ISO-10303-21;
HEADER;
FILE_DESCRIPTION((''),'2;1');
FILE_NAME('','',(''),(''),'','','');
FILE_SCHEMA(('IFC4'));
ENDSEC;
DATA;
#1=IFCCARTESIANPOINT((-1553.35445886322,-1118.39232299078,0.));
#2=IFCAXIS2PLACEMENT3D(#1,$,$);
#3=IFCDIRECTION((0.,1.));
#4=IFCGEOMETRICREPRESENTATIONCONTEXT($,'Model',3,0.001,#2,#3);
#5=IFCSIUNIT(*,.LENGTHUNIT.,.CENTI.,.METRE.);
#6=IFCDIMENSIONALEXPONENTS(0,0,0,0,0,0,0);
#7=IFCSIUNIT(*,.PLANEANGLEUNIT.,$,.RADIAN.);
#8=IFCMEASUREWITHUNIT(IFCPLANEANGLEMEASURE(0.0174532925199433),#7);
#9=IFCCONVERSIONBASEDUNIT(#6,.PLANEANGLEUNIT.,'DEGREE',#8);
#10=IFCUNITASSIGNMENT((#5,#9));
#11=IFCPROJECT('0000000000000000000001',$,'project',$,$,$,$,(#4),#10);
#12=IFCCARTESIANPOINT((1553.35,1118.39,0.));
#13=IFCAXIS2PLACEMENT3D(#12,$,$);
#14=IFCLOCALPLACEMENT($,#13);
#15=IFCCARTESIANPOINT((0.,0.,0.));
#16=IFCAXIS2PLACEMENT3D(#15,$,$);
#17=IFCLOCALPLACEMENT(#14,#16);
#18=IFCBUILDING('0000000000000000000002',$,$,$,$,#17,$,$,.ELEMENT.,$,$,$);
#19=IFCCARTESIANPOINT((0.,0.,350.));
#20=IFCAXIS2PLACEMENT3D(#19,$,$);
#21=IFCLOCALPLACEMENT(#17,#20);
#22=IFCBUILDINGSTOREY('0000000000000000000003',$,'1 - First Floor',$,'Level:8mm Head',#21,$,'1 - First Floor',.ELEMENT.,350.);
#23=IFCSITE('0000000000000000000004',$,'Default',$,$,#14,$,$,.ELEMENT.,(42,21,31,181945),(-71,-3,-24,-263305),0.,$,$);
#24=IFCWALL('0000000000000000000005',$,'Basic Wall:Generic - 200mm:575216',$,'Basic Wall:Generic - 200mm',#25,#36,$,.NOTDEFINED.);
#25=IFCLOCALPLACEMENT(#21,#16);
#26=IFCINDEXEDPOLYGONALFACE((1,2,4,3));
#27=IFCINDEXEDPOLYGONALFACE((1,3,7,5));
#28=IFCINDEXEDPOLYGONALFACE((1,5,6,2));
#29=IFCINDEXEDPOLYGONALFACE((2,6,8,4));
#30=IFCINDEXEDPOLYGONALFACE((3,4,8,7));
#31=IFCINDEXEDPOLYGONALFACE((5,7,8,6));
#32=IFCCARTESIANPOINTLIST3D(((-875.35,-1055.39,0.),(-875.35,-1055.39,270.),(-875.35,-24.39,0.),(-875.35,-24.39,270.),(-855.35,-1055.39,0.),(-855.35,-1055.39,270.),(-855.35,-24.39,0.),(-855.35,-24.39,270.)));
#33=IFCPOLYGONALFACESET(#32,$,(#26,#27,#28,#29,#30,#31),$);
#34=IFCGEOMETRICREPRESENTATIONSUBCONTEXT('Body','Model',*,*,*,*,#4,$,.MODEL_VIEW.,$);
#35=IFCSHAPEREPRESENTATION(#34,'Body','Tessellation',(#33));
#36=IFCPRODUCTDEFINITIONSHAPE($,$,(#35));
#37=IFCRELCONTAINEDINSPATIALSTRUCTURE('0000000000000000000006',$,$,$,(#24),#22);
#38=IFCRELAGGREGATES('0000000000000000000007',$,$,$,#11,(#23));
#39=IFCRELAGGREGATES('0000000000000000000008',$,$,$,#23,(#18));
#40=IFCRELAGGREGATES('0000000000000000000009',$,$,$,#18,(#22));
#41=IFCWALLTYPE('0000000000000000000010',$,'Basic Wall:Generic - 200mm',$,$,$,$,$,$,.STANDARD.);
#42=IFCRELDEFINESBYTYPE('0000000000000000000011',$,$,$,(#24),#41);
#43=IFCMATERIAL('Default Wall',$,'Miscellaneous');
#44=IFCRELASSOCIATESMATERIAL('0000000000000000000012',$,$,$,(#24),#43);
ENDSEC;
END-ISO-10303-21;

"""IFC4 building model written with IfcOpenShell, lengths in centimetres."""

from ifc_helpers import new_model, entity, si_unit, converted_unit, direction, frame, origin, place, context, subcontext, project, spatial, indexed_curve, outline, extrude, material, type_object, element, save


model = new_model("IFC4")

# Units and contexts
model_context = context("Model", 3, precision=0.001, world=frame((-1553.35445886322, -1118.39232299078, 0.0)), true_north=direction((0.0, 1.0)))
body_context = subcontext(model_context, "Body", "Model", "MODEL_VIEW")
ifc_project = project(units=[si_unit("LENGTHUNIT", "METRE", prefix="CENTI"), converted_unit("PLANEANGLEUNIT", "DEGREE", entity("IfcPlaneAngleMeasure", 0.0174532925199433), si_unit("PLANEANGLEUNIT", "RADIAN"), dimensions=[0, 0, 0, 0, 0, 0, 0])], contexts=[model_context])

# Site, building, storey
site_placement = place(None, frame((1553.35, 1118.39, 0.0)))
site = spatial("IfcSite", under=ifc_project, at=site_placement, Name="Default", CompositionType="ELEMENT", RefLatitude=(42, 21, 31, 181945), RefLongitude=(-71, -3, -24, -263305), RefElevation=0.0)
building_placement = place(site_placement, origin())
building = spatial("IfcBuilding", under=site, at=building_placement, CompositionType="ELEMENT")
storey_placement = place(building_placement, frame((0.0, 0.0, 350.0)))
storey = spatial("IfcBuildingStorey", under=building, at=storey_placement, Name="1 - First Floor", ObjectType="Level:8mm Head", LongName="1 - First Floor", CompositionType="ELEMENT", Elevation=350.0)

# Wall
ifc_material_1 = material(Name="Default Wall", Category="Miscellaneous")
wall_type_1 = type_object("IfcWallType", Name="Basic Wall:Generic - 200mm", PredefinedType="STANDARD")
wall_1_placement = place(storey_placement, frame((-865.35, -24.39, 0.0), z_axis=(0.0, 0.0, 1.0), x_axis=(0.0, -1.0, 0.0)))
element("IfcWall", 1, at=wall_1_placement, inside=storey, type_object=wall_type_1, material=ifc_material_1, Name="Basic Wall:Generic - 200mm:575216", ObjectType="Basic Wall:Generic - 200mm", PredefinedType="NOTDEFINED", context=body_context, shape_type="SweptSolid", body=[
    extrude(outline(indexed_curve([(1031.0, 10.0), (0.0, 10.0), (0.0, -10.0), (1031.0, -10.0), (1031.0, 10.0)], self_intersect=False)), origin(), (0.0, 0.0, 1.0), 270.0),
])

save(model, "model.ifc")
